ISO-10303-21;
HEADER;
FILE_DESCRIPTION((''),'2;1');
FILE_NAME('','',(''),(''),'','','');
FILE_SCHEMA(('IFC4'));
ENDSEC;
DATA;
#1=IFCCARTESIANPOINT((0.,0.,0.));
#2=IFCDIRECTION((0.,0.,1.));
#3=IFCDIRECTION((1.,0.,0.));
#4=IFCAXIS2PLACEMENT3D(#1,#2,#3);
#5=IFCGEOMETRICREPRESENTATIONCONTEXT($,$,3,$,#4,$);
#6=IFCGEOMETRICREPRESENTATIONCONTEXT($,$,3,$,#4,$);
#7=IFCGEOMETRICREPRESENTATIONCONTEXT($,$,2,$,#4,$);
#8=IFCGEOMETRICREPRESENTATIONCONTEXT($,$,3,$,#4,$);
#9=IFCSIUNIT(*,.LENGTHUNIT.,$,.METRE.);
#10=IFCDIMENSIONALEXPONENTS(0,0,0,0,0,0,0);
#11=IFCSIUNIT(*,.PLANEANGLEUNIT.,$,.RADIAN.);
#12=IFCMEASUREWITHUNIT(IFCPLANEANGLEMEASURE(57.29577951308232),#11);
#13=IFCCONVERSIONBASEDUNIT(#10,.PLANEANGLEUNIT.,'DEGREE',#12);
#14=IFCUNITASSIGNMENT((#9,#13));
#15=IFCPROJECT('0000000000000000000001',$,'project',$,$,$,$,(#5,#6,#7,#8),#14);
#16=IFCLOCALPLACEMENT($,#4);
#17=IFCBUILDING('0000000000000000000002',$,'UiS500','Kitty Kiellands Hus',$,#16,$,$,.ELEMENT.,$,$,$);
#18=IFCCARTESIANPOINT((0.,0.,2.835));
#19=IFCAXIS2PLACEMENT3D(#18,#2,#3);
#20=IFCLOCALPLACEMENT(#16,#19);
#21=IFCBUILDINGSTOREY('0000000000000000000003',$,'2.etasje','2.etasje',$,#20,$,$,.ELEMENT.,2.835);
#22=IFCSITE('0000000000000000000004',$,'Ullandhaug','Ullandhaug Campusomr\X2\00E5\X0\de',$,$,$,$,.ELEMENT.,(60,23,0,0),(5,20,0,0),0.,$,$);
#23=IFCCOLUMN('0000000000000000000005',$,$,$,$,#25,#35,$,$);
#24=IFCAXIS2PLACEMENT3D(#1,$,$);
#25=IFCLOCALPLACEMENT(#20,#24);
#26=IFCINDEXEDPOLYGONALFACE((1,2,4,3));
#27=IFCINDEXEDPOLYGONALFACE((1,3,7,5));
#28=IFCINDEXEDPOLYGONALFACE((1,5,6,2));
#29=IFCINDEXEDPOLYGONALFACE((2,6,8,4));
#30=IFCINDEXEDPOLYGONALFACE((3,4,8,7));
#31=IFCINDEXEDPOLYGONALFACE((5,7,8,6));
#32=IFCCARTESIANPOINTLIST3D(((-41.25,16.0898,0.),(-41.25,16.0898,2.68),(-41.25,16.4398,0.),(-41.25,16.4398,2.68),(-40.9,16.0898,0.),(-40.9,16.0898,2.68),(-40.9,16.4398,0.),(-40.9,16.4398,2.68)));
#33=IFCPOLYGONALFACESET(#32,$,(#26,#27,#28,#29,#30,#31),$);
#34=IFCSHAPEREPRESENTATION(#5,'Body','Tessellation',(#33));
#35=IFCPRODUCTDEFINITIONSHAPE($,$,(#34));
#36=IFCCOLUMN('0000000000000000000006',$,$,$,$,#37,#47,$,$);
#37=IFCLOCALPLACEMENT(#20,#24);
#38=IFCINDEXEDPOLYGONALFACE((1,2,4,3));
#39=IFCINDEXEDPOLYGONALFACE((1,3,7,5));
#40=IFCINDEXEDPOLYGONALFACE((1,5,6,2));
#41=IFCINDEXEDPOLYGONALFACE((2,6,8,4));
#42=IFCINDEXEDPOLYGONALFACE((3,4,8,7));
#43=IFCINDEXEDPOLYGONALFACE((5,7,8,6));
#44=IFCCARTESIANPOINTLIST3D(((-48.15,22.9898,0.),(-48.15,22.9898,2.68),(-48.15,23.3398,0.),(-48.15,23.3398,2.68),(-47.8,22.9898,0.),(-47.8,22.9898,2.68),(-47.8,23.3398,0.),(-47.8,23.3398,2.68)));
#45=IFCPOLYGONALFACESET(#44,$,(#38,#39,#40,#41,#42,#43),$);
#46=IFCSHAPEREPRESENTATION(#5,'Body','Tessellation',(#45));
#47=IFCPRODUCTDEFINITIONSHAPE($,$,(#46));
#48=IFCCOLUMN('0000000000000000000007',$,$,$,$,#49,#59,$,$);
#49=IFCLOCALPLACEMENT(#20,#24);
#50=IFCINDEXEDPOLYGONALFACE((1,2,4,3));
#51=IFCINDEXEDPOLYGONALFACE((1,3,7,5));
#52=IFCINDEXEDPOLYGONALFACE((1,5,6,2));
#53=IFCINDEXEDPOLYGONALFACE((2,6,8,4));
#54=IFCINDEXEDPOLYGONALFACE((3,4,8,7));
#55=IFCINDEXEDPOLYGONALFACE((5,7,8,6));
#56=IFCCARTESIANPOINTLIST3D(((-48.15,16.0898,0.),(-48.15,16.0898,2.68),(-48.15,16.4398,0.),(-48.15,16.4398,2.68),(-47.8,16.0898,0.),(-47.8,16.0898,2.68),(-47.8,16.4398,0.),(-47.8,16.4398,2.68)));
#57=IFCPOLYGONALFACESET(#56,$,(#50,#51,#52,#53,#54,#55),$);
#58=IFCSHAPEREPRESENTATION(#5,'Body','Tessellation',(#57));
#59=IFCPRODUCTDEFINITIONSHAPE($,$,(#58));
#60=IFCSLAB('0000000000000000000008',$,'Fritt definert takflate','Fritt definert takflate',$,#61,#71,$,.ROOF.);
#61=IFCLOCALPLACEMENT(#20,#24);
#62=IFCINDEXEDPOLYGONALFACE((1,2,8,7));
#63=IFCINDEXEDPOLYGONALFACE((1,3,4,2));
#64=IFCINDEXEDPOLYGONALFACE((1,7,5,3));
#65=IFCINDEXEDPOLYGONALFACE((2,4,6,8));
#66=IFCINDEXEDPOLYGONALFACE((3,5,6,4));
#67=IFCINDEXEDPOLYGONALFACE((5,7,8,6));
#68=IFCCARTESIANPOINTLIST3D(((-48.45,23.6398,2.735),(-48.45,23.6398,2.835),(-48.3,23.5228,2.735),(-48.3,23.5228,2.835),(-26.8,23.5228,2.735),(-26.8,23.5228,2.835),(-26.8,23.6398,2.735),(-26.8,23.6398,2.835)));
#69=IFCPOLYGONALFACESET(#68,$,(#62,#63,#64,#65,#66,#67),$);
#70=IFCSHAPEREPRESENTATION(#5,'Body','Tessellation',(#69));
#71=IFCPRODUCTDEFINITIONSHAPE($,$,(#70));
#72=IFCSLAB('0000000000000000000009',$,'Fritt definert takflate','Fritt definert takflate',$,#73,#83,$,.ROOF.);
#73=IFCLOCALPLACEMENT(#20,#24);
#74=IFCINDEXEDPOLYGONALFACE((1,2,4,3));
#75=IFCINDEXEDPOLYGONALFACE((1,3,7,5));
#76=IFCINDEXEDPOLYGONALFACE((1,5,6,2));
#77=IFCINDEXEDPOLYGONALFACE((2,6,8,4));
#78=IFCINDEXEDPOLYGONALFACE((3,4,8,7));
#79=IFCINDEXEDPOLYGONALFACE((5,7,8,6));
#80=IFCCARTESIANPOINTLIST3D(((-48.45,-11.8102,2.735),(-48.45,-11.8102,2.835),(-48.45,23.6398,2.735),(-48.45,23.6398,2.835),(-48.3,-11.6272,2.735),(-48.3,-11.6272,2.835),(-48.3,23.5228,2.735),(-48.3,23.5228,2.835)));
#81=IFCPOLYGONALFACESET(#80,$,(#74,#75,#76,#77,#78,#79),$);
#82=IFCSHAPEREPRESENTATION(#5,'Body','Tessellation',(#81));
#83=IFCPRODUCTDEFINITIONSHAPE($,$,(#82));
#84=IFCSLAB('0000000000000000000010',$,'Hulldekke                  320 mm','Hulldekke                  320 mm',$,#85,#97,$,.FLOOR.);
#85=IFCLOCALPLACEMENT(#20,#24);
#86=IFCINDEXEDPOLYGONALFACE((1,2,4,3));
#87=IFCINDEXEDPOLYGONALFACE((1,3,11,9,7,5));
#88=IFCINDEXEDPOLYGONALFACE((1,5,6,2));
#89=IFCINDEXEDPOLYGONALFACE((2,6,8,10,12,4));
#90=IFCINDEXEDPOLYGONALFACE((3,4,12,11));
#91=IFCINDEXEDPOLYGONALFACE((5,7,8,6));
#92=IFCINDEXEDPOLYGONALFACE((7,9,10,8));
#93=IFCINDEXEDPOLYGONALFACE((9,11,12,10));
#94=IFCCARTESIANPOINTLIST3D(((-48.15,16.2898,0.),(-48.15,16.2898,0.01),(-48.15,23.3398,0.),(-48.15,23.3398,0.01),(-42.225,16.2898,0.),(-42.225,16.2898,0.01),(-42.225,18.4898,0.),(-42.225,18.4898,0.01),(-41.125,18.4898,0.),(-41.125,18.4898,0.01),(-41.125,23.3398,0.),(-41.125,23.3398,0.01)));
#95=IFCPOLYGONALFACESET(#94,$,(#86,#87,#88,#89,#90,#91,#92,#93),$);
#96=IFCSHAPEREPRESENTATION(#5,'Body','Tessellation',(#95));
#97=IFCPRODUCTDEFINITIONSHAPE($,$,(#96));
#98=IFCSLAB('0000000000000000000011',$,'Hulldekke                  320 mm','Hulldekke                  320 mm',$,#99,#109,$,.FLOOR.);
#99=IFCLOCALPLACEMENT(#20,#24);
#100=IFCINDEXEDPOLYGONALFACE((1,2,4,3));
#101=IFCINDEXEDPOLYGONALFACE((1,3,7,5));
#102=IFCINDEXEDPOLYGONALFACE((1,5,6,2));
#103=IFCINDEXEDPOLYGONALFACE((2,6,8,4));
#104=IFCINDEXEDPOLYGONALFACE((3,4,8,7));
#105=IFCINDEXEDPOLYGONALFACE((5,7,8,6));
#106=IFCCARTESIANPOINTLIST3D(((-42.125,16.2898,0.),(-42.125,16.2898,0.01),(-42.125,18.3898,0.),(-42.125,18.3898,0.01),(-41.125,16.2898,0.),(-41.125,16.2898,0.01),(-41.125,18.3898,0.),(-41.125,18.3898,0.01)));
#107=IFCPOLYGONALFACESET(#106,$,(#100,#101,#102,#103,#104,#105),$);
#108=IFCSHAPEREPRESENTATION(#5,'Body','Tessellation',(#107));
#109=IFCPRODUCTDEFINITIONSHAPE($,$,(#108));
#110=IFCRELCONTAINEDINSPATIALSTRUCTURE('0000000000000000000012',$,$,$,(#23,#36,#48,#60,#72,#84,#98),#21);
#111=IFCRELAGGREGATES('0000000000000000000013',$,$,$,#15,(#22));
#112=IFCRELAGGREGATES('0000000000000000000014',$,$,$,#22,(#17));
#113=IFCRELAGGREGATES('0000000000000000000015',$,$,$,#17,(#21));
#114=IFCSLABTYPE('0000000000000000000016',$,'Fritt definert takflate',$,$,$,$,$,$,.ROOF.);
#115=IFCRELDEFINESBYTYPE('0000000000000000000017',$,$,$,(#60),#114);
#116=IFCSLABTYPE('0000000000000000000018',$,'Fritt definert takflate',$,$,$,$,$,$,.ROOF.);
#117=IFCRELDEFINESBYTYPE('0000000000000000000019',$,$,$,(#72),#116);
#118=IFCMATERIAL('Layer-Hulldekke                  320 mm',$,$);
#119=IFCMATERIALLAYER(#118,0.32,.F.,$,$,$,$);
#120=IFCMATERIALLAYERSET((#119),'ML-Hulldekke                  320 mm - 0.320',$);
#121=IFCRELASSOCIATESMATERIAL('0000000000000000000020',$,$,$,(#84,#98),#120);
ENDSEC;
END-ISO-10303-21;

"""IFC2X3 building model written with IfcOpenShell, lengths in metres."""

from ifc_helpers import new_model, entity, si_unit, converted_unit, frame, origin_with_axes, origin_2d_with_axis, place, context, project, spatial, polyline, rectangle, outline, extrude, material, layer, layer_set, layer_usage, type_object, element, save


model = new_model("IFC2X3")

# Units and contexts
context_of_model_1 = context(None, 3, world=origin_with_axes())
context_of_model_2 = context(None, 3, world=origin_with_axes())
context_of_model_3 = context(None, 2, world=origin_with_axes())
context_of_model_4 = context(None, 3, world=origin_with_axes())
ifc_project = project(units=[si_unit("LENGTHUNIT", "METRE"), converted_unit("PLANEANGLEUNIT", "DEGREE", entity("IfcPlaneAngleMeasure", 57.29577951308232), si_unit("PLANEANGLEUNIT", "RADIAN"), dimensions=[0, 0, 0, 0, 0, 0, 0])], contexts=[context_of_model_1, context_of_model_2, context_of_model_3, context_of_model_4])

# Site, building, storey
site = spatial("IfcSite", under=ifc_project, Name="Ullandhaug", Description="Ullandhaug Campusområde", CompositionType="ELEMENT", RefLatitude=(60, 23, 0, 0), RefLongitude=(5, 20, 0, 0), RefElevation=0.0)
building_placement = place(None, origin_with_axes())
building = spatial("IfcBuilding", under=site, at=building_placement, Name="UiS500", Description="Kitty Kiellands Hus", CompositionType="ELEMENT")
storey_placement = place(building_placement, frame((0.0, 0.0, 2.835), z_axis=(0.0, 0.0, 1.0), x_axis=(1.0, 0.0, 0.0)))
storey = spatial("IfcBuildingStorey", under=building, at=storey_placement, Name="2.etasje", Description="2.etasje", CompositionType="ELEMENT", Elevation=2.835)

# Columns
for number, where, z_axis, x_axis in (
    (1, (-41.075, 16.2648, 0.0), (0.0, 0.0, 1.0), (1.0, 0.0, 0.0)),
    (2, (-47.975, 23.1648, 0.0), (0.0, 0.0, 1.0), (1.0, 0.0, 0.0)),
    (3, (-47.975, 16.2648, 0.0), (0.0, 0.0, 1.0), (1.0, 0.0, 0.0)),
):
    element("IfcColumn", number, at=place(storey_placement, frame(where, z_axis=z_axis, x_axis=x_axis)), inside=storey, context=context_of_model_1, shape_type="SweptSolid", body=[
        extrude(rectangle(XDim=0.35, YDim=0.35, at=origin_2d_with_axis()), origin_with_axes(), (0.0, 0.0, 1.0), 2.68),
    ])

# Slabs
slab_type_1 = type_object("IfcSlabType", Name="Fritt definert takflate", PredefinedType="ROOF")
slab_1_placement = place(storey_placement, frame((-48.45, 23.6398, 2.735), z_axis=(0.0, 0.0, 1.0), x_axis=(0.788504, -0.61503, 0.0)))
element("IfcSlab", 4, at=slab_1_placement, inside=storey, type_object=slab_type_1, Name="Fritt definert takflate", Description="Fritt definert takflate", PredefinedType="ROOF", context=context_of_model_1, shape_type="SweptSolid", body=[
    extrude(outline(polyline([(0.0, 0.0), (0.1902, 0.0), (17.1431, 13.2231), (17.0711, 13.3154), (0.0, 0.0)])), origin_with_axes(), (0.0, 0.0, 1.0), 0.1),
])
slab_type_2 = type_object("IfcSlabType", Name="Fritt definert takflate", PredefinedType="ROOF")
slab_2_placement = place(storey_placement, frame((-48.3, 23.5228, 2.735), z_axis=(0.0, 0.0, 1.0), x_axis=(-0.788504, 0.61503, 0.0)))
element("IfcSlab", 5, at=slab_2_placement, inside=storey, type_object=slab_type_2, Name="Fritt definert takflate", Description="Fritt definert takflate", PredefinedType="ROOF", context=context_of_model_1, shape_type="SweptSolid", body=[
    extrude(outline(polyline([(0.0, 0.0), (0.1902, 0.0), (-21.6126, 27.9525), (-21.6183, 27.7159), (0.0, 0.0)])), origin_with_axes(), (0.0, 0.0, 1.0), 0.1),
])
ifc_material_1 = material(Name="Layer-Hulldekke                  320 mm")
ifc_layer_1 = layer(ifc_material_1, 0.32, ventilated=False)
ifc_layer_set_1 = layer_set([ifc_layer_1], Name="ML-Hulldekke                  320 mm - 0.320")
ifc_layer_usage_1 = layer_usage(ifc_layer_set_1, "AXIS2", "POSITIVE", 0.0)
slab_3_placement = place(storey_placement, frame((-48.15, 23.3398, 0.0), z_axis=(0.0, 0.0, 1.0), x_axis=(1.0, 0.0, 0.0)))
element("IfcSlab", 6, at=slab_3_placement, inside=storey, material=ifc_layer_usage_1, Name="Hulldekke                  320 mm", Description="Hulldekke                  320 mm", PredefinedType="FLOOR", context=context_of_model_1, shape_type="SweptSolid", body=[
    extrude(outline(polyline([(0.0, 0.0), (7.05, 0.0), (7.05, 5.925), (4.85, 5.925), (4.85, 7.025), (0.0, 7.025), (0.0, 0.0)])), frame((0.0, 0.0, 0.0), z_axis=(0.0, 0.0, 1.0), x_axis=(0.0, -1.0, 0.0)), (0.0, 0.0, 1.0), 0.01),
])
slab_4_placement = place(storey_placement, frame((-42.125, 16.2898, 0.0), z_axis=(0.0, 0.0, 1.0), x_axis=(1.0, 0.0, 0.0)))
element("IfcSlab", 7, at=slab_4_placement, inside=storey, material=ifc_layer_usage_1, Name="Hulldekke                  320 mm", Description="Hulldekke                  320 mm", PredefinedType="FLOOR", context=context_of_model_1, shape_type="SweptSolid", body=[
    extrude(outline(polyline([(0.0, 0.0), (1.0, 0.0), (1.0, 2.1), (0.0, 2.1), (0.0, 0.0)])), origin_with_axes(), (0.0, 0.0, 1.0), 0.01),
])

save(model, "model.ifc")
